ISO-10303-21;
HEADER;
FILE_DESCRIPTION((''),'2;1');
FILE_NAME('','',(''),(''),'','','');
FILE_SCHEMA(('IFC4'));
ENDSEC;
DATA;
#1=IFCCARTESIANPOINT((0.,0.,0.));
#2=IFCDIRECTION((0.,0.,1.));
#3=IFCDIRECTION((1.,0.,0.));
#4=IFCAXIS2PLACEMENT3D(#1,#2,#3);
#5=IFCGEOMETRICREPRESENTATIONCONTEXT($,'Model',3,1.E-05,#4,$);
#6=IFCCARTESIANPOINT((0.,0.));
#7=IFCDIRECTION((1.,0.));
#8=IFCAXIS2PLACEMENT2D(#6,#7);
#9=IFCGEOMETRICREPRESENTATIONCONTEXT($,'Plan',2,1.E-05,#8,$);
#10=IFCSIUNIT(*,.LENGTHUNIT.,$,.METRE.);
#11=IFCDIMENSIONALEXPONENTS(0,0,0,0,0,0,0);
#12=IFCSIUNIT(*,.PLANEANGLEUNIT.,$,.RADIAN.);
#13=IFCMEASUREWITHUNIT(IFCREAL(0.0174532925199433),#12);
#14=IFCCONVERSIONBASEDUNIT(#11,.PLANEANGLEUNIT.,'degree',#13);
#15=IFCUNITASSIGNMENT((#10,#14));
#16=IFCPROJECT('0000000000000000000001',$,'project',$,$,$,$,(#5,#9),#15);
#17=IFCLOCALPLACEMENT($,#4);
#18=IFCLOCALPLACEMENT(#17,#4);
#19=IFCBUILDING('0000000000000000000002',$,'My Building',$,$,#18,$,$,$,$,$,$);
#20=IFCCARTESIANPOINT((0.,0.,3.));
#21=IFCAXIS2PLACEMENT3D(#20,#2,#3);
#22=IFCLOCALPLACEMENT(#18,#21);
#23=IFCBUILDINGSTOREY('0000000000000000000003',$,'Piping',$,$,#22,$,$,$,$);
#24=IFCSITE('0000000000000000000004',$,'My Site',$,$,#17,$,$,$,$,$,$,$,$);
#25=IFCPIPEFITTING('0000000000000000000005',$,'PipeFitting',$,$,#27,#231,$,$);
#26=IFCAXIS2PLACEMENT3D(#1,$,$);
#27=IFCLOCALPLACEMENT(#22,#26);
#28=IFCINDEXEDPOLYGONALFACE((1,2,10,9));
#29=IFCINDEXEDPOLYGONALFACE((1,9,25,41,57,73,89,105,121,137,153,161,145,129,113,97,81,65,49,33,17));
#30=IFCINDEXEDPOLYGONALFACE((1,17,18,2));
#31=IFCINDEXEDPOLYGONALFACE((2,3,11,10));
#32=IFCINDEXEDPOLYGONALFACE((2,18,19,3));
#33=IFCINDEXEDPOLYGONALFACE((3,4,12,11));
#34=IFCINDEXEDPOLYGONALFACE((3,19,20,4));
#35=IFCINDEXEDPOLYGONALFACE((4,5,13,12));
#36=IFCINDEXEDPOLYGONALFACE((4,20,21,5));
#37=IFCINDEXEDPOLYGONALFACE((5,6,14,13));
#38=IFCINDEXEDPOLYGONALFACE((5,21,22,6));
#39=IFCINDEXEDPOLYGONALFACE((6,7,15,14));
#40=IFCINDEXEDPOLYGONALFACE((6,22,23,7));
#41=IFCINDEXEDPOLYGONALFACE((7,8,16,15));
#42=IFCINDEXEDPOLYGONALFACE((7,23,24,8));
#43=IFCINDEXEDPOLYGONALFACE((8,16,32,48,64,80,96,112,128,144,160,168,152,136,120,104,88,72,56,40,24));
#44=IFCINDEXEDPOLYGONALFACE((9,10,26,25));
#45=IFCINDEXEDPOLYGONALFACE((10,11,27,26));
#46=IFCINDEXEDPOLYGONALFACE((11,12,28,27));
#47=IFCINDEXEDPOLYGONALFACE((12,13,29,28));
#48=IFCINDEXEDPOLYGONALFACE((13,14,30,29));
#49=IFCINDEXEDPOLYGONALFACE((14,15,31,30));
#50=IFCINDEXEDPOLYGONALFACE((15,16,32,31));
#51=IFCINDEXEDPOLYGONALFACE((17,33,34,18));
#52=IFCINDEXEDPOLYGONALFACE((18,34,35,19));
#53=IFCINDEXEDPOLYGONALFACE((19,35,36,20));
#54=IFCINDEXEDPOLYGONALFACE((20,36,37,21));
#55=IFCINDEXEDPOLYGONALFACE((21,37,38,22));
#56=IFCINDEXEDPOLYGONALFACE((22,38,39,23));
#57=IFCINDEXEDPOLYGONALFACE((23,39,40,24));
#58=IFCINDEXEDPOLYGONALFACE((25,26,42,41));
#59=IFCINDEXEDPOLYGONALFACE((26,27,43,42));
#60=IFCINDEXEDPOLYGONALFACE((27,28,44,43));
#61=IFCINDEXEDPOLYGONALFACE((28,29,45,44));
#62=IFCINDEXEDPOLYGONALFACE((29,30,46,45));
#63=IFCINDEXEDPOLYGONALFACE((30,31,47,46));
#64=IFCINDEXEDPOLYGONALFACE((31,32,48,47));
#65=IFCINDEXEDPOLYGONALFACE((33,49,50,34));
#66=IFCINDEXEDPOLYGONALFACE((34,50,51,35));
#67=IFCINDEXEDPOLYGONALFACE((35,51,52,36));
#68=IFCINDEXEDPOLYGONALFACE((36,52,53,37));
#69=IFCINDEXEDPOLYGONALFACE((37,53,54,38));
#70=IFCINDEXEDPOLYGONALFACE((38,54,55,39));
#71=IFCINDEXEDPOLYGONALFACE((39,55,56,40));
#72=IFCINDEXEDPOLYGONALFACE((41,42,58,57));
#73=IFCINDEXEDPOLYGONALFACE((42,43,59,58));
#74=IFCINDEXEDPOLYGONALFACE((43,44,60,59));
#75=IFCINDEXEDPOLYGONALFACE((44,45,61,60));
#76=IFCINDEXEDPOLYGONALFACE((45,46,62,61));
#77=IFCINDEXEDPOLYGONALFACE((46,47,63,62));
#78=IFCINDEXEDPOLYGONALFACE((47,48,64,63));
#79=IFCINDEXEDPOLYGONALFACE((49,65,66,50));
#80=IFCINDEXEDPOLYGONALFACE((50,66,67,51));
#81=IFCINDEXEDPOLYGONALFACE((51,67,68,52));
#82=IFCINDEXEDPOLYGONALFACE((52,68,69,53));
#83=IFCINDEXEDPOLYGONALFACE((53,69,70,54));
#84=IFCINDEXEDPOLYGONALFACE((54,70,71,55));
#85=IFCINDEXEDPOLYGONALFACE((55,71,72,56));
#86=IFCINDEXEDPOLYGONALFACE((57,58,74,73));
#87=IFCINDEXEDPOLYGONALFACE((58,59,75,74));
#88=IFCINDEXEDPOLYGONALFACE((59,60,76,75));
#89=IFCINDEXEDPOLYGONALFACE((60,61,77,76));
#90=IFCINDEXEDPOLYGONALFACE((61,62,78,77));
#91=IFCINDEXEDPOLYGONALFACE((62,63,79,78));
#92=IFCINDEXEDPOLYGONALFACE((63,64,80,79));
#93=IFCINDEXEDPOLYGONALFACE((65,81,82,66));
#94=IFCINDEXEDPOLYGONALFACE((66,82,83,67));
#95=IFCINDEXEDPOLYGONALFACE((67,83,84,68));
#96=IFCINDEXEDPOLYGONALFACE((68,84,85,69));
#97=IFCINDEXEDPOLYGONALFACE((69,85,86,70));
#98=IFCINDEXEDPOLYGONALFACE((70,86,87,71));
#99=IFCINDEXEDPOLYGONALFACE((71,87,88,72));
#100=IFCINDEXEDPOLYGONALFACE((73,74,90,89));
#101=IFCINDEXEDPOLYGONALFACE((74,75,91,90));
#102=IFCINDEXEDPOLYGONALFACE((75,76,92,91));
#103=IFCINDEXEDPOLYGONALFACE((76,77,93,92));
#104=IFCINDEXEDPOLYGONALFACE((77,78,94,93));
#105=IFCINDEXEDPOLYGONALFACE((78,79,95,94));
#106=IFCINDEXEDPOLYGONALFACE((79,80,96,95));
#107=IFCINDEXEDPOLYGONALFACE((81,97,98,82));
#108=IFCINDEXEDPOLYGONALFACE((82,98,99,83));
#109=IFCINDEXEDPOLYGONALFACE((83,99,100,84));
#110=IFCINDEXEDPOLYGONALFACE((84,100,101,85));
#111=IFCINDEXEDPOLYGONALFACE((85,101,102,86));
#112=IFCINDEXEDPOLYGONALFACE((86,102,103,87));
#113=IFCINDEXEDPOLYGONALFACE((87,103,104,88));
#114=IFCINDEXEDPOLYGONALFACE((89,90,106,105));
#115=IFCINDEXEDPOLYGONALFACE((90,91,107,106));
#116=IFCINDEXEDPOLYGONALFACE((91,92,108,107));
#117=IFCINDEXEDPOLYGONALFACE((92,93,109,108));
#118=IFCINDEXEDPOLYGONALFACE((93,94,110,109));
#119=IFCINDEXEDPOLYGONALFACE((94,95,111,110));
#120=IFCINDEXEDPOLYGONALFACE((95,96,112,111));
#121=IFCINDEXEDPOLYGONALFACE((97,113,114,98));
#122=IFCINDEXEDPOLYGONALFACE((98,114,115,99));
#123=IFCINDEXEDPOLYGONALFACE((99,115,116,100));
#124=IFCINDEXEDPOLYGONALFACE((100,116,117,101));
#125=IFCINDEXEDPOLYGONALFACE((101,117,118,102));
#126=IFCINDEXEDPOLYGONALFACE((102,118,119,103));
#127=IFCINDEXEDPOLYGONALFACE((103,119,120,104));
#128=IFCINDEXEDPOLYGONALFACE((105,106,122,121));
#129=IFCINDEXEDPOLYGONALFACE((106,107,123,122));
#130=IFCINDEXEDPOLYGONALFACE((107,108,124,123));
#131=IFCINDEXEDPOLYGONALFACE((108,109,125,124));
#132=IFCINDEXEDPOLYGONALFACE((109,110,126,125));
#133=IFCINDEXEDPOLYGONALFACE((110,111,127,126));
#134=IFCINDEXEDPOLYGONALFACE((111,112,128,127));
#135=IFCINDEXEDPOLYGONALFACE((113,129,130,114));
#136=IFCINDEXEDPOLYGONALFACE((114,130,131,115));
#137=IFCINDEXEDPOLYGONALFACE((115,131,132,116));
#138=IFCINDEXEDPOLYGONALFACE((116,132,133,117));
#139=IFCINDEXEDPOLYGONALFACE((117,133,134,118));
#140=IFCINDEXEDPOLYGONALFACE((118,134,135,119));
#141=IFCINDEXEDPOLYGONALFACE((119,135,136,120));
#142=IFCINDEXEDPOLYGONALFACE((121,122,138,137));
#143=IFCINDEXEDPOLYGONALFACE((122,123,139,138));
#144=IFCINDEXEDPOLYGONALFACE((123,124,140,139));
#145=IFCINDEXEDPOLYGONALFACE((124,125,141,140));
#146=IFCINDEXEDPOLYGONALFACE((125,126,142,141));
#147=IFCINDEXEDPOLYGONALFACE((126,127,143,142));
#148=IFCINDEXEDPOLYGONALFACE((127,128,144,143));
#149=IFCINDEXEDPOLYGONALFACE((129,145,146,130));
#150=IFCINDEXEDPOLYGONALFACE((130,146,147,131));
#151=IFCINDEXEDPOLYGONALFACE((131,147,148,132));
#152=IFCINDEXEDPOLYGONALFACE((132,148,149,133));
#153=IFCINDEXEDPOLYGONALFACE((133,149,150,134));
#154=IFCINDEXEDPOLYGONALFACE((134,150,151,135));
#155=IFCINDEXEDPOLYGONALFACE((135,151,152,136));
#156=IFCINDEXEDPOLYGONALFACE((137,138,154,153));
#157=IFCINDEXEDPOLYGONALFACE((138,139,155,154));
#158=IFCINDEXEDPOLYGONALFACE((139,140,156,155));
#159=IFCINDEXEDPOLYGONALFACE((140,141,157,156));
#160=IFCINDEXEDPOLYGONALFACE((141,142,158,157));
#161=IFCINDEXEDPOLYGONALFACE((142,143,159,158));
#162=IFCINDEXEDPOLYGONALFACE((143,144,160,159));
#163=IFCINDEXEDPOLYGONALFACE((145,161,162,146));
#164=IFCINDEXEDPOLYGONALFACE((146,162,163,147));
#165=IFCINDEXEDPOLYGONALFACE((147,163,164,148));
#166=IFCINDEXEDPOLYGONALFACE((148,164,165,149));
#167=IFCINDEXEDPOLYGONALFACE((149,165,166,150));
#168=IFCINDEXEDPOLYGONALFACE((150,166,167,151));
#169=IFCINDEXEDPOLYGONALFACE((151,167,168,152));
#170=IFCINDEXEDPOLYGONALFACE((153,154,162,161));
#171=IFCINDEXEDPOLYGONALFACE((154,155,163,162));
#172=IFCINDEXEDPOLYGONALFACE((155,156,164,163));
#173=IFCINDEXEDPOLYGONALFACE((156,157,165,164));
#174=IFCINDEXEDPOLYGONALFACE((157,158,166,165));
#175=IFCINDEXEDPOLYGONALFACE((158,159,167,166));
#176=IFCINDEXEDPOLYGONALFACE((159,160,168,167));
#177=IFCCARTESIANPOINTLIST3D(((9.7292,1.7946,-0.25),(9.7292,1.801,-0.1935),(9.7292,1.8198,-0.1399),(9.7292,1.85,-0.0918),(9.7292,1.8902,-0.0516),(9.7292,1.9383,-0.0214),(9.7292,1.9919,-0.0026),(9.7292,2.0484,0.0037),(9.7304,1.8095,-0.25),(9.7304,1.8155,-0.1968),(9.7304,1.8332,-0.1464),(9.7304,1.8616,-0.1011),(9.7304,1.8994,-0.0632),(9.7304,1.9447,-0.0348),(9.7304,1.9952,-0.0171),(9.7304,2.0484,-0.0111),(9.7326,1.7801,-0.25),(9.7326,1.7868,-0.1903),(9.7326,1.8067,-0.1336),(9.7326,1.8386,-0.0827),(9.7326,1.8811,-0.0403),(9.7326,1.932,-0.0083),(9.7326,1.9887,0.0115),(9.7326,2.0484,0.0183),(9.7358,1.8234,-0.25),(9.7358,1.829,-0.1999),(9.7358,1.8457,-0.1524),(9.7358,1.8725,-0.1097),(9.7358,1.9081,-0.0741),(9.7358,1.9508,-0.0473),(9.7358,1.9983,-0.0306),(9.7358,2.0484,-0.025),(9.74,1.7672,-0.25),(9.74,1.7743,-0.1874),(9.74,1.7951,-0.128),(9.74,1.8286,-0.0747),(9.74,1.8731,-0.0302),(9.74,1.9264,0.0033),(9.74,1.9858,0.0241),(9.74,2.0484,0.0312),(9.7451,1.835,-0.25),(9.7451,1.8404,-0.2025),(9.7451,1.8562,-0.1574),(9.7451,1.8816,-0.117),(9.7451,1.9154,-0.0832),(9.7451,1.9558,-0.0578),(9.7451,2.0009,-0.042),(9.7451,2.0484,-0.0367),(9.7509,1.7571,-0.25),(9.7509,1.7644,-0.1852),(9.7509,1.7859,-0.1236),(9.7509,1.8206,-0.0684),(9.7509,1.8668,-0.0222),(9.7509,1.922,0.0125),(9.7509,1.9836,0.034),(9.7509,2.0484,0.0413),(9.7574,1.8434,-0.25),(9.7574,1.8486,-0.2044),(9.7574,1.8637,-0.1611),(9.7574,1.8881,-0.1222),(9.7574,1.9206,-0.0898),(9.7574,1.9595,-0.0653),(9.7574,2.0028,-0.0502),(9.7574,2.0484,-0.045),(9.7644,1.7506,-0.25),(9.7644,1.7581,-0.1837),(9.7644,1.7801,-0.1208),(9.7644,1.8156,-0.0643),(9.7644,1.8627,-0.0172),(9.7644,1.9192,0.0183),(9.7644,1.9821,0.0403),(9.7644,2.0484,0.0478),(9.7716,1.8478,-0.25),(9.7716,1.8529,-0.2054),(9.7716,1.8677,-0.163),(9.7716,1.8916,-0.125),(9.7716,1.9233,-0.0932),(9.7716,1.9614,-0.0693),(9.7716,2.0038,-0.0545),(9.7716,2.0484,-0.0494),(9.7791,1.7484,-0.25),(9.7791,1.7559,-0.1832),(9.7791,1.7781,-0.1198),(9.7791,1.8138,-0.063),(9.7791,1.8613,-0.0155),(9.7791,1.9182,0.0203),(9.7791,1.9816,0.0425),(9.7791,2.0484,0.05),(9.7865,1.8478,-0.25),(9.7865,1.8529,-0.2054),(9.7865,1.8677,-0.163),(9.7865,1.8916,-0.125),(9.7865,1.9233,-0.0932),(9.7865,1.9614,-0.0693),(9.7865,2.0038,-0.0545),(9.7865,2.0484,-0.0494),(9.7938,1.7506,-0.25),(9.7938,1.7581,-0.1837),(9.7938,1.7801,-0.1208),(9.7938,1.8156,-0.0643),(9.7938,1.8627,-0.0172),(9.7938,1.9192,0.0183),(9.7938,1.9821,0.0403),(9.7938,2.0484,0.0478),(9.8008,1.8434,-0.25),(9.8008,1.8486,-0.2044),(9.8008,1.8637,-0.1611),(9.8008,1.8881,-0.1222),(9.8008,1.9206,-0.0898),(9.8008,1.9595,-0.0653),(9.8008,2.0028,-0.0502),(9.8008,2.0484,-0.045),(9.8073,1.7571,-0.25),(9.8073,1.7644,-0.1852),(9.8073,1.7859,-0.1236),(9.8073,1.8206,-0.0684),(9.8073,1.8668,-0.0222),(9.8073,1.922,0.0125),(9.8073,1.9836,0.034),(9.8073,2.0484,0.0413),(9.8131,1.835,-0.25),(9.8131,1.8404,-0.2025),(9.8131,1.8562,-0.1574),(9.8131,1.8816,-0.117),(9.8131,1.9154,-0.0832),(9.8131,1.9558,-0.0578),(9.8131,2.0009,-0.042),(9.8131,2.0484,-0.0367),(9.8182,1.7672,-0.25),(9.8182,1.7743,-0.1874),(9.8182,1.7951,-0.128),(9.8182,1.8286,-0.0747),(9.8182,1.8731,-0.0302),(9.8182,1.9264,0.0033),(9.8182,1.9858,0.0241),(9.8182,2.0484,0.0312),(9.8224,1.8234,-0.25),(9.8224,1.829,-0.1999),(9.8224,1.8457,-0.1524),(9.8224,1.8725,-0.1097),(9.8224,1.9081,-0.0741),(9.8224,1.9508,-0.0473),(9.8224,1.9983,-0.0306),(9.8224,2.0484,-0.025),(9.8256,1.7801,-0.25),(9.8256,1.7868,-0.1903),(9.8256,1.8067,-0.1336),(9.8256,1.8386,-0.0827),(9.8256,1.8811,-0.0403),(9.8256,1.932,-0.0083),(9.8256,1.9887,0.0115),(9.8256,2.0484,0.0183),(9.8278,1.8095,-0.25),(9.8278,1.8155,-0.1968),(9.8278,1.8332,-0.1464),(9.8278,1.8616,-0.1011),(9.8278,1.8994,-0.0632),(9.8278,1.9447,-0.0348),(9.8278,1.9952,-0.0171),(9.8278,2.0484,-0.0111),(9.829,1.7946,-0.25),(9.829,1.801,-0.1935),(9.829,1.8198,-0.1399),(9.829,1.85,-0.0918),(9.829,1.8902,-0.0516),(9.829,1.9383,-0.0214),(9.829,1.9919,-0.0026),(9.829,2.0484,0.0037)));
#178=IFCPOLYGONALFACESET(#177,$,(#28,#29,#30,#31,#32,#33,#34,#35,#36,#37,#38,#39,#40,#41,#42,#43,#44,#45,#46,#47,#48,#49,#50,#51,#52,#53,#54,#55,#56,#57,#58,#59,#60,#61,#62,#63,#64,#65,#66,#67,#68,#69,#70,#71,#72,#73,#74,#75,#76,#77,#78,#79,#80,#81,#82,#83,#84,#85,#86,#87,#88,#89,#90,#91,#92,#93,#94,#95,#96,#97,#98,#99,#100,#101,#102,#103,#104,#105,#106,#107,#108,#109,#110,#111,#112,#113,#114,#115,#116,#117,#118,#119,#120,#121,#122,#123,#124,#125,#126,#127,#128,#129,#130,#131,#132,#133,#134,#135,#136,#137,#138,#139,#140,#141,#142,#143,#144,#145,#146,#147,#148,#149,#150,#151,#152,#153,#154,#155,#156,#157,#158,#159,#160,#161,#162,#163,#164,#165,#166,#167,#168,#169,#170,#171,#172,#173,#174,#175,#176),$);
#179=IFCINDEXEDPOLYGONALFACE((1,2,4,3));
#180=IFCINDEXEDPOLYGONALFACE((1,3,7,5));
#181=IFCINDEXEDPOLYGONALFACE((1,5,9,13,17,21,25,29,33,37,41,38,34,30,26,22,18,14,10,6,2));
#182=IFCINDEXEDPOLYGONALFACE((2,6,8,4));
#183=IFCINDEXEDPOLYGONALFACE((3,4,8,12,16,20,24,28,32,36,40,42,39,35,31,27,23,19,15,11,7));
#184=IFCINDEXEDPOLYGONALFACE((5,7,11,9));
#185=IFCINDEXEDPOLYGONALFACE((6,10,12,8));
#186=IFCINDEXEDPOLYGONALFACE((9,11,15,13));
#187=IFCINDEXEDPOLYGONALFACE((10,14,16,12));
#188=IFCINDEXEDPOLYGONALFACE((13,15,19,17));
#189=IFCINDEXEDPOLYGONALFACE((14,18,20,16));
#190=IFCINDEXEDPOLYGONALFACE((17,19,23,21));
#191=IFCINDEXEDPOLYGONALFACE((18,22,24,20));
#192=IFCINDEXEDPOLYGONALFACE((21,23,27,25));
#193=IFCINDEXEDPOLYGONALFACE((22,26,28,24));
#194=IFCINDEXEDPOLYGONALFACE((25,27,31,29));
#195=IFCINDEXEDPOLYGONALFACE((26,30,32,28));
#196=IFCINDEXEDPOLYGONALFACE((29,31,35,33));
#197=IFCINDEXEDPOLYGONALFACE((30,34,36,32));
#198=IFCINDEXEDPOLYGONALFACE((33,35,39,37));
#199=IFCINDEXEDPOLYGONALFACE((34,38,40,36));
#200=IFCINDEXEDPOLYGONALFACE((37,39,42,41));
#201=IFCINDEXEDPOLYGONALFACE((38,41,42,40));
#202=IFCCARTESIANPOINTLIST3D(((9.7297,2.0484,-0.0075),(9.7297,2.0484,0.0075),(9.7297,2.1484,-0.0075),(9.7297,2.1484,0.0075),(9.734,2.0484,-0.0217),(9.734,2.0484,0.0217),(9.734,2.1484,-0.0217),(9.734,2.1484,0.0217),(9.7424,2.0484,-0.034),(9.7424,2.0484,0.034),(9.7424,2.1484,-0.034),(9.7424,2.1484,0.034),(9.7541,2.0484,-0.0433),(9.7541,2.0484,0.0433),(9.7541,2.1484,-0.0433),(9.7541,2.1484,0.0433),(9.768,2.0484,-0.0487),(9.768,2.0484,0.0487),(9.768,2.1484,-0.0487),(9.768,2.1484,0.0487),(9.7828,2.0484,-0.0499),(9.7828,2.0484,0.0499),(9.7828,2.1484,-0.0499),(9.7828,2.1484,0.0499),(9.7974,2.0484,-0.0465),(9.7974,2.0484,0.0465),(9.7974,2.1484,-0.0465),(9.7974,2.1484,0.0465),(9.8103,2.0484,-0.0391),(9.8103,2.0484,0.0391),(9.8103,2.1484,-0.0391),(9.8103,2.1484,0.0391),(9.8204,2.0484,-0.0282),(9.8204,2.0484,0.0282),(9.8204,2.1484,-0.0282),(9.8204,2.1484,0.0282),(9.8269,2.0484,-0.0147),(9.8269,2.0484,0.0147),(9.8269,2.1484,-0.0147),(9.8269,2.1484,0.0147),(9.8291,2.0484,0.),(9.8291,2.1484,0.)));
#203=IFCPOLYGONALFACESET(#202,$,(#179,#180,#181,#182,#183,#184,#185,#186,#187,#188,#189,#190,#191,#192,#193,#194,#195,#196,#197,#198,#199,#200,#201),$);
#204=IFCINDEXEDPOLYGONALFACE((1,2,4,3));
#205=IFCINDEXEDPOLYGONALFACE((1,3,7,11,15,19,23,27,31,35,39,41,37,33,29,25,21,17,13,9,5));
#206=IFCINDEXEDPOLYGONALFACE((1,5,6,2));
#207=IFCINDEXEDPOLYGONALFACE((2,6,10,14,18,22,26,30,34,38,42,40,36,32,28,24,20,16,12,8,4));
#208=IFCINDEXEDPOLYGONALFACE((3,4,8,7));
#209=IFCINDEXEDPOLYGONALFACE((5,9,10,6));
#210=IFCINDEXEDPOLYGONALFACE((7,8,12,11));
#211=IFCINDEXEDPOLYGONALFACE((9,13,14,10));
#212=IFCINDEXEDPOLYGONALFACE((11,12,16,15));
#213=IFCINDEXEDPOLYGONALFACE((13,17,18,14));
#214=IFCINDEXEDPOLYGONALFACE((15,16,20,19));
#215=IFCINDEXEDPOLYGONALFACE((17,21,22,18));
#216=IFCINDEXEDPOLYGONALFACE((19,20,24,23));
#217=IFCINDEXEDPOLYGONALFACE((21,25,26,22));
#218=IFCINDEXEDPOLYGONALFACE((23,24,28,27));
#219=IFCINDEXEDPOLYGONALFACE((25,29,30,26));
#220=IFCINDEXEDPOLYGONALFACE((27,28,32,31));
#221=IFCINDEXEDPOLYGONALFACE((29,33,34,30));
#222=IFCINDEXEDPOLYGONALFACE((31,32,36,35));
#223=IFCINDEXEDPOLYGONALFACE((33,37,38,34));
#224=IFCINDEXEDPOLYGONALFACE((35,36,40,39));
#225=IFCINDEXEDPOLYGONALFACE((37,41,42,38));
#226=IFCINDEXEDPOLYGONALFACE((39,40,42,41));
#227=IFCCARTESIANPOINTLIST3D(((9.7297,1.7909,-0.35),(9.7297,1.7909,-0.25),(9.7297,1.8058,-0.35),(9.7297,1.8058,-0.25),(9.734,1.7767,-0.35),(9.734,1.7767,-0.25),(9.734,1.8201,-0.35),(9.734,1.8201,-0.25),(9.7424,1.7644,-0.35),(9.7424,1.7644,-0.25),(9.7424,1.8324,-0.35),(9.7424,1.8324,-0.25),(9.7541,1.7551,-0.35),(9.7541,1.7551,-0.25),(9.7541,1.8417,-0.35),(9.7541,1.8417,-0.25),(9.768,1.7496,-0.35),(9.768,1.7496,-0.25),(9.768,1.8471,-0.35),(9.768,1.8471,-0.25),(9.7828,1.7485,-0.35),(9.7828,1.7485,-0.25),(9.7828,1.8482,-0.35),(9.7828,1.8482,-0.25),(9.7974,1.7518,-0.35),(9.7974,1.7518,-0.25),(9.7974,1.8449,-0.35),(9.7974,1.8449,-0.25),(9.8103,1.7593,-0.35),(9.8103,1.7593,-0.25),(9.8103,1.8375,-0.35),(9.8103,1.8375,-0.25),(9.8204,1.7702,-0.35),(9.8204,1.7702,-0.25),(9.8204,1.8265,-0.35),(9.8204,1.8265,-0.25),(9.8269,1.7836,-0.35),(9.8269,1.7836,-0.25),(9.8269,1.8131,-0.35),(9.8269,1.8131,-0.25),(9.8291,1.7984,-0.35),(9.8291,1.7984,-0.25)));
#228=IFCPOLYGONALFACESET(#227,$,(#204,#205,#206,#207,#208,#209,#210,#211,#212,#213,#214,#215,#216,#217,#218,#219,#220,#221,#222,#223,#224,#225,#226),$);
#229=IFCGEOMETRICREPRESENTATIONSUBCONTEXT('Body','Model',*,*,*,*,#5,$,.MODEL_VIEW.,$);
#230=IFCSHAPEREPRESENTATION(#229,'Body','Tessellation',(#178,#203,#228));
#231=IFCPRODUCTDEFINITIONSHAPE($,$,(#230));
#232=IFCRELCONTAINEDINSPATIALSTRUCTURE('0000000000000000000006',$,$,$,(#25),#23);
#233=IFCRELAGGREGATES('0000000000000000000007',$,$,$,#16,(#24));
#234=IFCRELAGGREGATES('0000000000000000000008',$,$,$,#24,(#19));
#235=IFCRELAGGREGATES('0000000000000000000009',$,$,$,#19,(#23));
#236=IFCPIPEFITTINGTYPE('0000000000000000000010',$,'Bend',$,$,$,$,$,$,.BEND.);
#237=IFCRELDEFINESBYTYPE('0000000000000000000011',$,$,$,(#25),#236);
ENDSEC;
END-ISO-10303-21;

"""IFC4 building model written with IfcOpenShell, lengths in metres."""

from ifc_helpers import new_model, entity, si_unit, converted_unit, frame, origin_with_axes, origin_2d_with_axis, place, context, subcontext, project, spatial, line, indexed_curve, circle, outline, extrude, source, transform, mapped, type_object, type_shapes, element, save


model = new_model("IFC4")

# Units and contexts
model_context = context("Model", 3, precision=1e-05, world=origin_with_axes())
plan_context = context("Plan", 2, precision=1e-05, world=origin_2d_with_axis())
body_context = subcontext(model_context, "Body", "Model", "MODEL_VIEW")
ifc_project = project(units=[si_unit("LENGTHUNIT", "METRE"), converted_unit("PLANEANGLEUNIT", "degree", entity("IfcReal", 0.0174532925199433), si_unit("PLANEANGLEUNIT", "RADIAN"), dimensions=[0, 0, 0, 0, 0, 0, 0])], contexts=[model_context, plan_context])

# Site, building, storey
site_placement = place(None, origin_with_axes())
site = spatial("IfcSite", under=ifc_project, at=site_placement, Name="My Site")
building_placement = place(site_placement, origin_with_axes())
building = spatial("IfcBuilding", under=site, at=building_placement, Name="My Building")
storey_placement = place(building_placement, frame((0.0, 0.0, 3.0), z_axis=(0.0, 0.0, 1.0), x_axis=(1.0, 0.0, 0.0)))
storey = spatial("IfcBuildingStorey", under=building, at=storey_placement, Name="Piping")

# Pipe fitting, opening
pipe_fitting_type = type_object("IfcPipeFittingType", Name="Bend", PredefinedType="BEND")
shared_shape = source(origin_with_axes(), body_context, "Body", "SolidModel", [
    entity("IfcSweptDiskSolid", entity("IfcIndexedPolyCurve", entity("IfcCartesianPointList3D", [[0.0, 0.0, 0.1], [0.0, -0.0732, 0.2768], [0.0, -0.25, 0.35]]), [entity("IfcArcIndex", [1, 2, 3])]), 0.05),
    extrude(circle(Radius=0.05), origin_with_axes(), (0.0, 0.0, 1.0), 0.1),
    extrude(circle(Radius=0.05), frame((0.0, -0.25, 0.35), z_axis=(0.0, -1.0, 0.0), x_axis=(1.0, 0.0, 0.0)), (0.0, 0.0, 1.0), 0.1),
])
type_shapes(pipe_fitting_type, [shared_shape])
pipe_fitting_1_placement = place(storey_placement, frame((9.7791, 2.1484, 0.0), z_axis=(0.0, -1.0, 0.0), x_axis=(1.0, 0.0, 0.0)))
pipe_fitting_1 = element("IfcPipeFitting", 1, at=pipe_fitting_1_placement, inside=storey, type_object=pipe_fitting_type, Name="PipeFitting", context=body_context, shape_type="MappedRepresentation", body=[
    mapped(shared_shape, transform((0.0, 0.0, 0.0), x_axis=(1.0, 0.0, 0.0), y_axis=(0.0, 1.0, 0.0), z_axis=(0.0, 0.0, 1.0), scale=1.0)),
])
opening_1_placement = place(pipe_fitting_1_placement, frame((-9.7791, -3.0, 2.1484), z_axis=(0.0, 1.0, 0.0), x_axis=(1.0, 0.0, 0.0)))
element("IfcOpeningElement", 2, at=opening_1_placement, cuts=pipe_fitting_1, PredefinedType="OPENING", context=body_context, shape_type="SweptSolid", body=[
    extrude(outline(indexed_curve([(0.0, 0.0), (0.5, 0.0), (0.5, 0.5), (0.0, 0.5)], segments=[line(1, 2, 3, 4, 1)])), origin_with_axes(), (0.0, 0.0, 1.0), 0.5),
])

save(model, "model.ifc")
